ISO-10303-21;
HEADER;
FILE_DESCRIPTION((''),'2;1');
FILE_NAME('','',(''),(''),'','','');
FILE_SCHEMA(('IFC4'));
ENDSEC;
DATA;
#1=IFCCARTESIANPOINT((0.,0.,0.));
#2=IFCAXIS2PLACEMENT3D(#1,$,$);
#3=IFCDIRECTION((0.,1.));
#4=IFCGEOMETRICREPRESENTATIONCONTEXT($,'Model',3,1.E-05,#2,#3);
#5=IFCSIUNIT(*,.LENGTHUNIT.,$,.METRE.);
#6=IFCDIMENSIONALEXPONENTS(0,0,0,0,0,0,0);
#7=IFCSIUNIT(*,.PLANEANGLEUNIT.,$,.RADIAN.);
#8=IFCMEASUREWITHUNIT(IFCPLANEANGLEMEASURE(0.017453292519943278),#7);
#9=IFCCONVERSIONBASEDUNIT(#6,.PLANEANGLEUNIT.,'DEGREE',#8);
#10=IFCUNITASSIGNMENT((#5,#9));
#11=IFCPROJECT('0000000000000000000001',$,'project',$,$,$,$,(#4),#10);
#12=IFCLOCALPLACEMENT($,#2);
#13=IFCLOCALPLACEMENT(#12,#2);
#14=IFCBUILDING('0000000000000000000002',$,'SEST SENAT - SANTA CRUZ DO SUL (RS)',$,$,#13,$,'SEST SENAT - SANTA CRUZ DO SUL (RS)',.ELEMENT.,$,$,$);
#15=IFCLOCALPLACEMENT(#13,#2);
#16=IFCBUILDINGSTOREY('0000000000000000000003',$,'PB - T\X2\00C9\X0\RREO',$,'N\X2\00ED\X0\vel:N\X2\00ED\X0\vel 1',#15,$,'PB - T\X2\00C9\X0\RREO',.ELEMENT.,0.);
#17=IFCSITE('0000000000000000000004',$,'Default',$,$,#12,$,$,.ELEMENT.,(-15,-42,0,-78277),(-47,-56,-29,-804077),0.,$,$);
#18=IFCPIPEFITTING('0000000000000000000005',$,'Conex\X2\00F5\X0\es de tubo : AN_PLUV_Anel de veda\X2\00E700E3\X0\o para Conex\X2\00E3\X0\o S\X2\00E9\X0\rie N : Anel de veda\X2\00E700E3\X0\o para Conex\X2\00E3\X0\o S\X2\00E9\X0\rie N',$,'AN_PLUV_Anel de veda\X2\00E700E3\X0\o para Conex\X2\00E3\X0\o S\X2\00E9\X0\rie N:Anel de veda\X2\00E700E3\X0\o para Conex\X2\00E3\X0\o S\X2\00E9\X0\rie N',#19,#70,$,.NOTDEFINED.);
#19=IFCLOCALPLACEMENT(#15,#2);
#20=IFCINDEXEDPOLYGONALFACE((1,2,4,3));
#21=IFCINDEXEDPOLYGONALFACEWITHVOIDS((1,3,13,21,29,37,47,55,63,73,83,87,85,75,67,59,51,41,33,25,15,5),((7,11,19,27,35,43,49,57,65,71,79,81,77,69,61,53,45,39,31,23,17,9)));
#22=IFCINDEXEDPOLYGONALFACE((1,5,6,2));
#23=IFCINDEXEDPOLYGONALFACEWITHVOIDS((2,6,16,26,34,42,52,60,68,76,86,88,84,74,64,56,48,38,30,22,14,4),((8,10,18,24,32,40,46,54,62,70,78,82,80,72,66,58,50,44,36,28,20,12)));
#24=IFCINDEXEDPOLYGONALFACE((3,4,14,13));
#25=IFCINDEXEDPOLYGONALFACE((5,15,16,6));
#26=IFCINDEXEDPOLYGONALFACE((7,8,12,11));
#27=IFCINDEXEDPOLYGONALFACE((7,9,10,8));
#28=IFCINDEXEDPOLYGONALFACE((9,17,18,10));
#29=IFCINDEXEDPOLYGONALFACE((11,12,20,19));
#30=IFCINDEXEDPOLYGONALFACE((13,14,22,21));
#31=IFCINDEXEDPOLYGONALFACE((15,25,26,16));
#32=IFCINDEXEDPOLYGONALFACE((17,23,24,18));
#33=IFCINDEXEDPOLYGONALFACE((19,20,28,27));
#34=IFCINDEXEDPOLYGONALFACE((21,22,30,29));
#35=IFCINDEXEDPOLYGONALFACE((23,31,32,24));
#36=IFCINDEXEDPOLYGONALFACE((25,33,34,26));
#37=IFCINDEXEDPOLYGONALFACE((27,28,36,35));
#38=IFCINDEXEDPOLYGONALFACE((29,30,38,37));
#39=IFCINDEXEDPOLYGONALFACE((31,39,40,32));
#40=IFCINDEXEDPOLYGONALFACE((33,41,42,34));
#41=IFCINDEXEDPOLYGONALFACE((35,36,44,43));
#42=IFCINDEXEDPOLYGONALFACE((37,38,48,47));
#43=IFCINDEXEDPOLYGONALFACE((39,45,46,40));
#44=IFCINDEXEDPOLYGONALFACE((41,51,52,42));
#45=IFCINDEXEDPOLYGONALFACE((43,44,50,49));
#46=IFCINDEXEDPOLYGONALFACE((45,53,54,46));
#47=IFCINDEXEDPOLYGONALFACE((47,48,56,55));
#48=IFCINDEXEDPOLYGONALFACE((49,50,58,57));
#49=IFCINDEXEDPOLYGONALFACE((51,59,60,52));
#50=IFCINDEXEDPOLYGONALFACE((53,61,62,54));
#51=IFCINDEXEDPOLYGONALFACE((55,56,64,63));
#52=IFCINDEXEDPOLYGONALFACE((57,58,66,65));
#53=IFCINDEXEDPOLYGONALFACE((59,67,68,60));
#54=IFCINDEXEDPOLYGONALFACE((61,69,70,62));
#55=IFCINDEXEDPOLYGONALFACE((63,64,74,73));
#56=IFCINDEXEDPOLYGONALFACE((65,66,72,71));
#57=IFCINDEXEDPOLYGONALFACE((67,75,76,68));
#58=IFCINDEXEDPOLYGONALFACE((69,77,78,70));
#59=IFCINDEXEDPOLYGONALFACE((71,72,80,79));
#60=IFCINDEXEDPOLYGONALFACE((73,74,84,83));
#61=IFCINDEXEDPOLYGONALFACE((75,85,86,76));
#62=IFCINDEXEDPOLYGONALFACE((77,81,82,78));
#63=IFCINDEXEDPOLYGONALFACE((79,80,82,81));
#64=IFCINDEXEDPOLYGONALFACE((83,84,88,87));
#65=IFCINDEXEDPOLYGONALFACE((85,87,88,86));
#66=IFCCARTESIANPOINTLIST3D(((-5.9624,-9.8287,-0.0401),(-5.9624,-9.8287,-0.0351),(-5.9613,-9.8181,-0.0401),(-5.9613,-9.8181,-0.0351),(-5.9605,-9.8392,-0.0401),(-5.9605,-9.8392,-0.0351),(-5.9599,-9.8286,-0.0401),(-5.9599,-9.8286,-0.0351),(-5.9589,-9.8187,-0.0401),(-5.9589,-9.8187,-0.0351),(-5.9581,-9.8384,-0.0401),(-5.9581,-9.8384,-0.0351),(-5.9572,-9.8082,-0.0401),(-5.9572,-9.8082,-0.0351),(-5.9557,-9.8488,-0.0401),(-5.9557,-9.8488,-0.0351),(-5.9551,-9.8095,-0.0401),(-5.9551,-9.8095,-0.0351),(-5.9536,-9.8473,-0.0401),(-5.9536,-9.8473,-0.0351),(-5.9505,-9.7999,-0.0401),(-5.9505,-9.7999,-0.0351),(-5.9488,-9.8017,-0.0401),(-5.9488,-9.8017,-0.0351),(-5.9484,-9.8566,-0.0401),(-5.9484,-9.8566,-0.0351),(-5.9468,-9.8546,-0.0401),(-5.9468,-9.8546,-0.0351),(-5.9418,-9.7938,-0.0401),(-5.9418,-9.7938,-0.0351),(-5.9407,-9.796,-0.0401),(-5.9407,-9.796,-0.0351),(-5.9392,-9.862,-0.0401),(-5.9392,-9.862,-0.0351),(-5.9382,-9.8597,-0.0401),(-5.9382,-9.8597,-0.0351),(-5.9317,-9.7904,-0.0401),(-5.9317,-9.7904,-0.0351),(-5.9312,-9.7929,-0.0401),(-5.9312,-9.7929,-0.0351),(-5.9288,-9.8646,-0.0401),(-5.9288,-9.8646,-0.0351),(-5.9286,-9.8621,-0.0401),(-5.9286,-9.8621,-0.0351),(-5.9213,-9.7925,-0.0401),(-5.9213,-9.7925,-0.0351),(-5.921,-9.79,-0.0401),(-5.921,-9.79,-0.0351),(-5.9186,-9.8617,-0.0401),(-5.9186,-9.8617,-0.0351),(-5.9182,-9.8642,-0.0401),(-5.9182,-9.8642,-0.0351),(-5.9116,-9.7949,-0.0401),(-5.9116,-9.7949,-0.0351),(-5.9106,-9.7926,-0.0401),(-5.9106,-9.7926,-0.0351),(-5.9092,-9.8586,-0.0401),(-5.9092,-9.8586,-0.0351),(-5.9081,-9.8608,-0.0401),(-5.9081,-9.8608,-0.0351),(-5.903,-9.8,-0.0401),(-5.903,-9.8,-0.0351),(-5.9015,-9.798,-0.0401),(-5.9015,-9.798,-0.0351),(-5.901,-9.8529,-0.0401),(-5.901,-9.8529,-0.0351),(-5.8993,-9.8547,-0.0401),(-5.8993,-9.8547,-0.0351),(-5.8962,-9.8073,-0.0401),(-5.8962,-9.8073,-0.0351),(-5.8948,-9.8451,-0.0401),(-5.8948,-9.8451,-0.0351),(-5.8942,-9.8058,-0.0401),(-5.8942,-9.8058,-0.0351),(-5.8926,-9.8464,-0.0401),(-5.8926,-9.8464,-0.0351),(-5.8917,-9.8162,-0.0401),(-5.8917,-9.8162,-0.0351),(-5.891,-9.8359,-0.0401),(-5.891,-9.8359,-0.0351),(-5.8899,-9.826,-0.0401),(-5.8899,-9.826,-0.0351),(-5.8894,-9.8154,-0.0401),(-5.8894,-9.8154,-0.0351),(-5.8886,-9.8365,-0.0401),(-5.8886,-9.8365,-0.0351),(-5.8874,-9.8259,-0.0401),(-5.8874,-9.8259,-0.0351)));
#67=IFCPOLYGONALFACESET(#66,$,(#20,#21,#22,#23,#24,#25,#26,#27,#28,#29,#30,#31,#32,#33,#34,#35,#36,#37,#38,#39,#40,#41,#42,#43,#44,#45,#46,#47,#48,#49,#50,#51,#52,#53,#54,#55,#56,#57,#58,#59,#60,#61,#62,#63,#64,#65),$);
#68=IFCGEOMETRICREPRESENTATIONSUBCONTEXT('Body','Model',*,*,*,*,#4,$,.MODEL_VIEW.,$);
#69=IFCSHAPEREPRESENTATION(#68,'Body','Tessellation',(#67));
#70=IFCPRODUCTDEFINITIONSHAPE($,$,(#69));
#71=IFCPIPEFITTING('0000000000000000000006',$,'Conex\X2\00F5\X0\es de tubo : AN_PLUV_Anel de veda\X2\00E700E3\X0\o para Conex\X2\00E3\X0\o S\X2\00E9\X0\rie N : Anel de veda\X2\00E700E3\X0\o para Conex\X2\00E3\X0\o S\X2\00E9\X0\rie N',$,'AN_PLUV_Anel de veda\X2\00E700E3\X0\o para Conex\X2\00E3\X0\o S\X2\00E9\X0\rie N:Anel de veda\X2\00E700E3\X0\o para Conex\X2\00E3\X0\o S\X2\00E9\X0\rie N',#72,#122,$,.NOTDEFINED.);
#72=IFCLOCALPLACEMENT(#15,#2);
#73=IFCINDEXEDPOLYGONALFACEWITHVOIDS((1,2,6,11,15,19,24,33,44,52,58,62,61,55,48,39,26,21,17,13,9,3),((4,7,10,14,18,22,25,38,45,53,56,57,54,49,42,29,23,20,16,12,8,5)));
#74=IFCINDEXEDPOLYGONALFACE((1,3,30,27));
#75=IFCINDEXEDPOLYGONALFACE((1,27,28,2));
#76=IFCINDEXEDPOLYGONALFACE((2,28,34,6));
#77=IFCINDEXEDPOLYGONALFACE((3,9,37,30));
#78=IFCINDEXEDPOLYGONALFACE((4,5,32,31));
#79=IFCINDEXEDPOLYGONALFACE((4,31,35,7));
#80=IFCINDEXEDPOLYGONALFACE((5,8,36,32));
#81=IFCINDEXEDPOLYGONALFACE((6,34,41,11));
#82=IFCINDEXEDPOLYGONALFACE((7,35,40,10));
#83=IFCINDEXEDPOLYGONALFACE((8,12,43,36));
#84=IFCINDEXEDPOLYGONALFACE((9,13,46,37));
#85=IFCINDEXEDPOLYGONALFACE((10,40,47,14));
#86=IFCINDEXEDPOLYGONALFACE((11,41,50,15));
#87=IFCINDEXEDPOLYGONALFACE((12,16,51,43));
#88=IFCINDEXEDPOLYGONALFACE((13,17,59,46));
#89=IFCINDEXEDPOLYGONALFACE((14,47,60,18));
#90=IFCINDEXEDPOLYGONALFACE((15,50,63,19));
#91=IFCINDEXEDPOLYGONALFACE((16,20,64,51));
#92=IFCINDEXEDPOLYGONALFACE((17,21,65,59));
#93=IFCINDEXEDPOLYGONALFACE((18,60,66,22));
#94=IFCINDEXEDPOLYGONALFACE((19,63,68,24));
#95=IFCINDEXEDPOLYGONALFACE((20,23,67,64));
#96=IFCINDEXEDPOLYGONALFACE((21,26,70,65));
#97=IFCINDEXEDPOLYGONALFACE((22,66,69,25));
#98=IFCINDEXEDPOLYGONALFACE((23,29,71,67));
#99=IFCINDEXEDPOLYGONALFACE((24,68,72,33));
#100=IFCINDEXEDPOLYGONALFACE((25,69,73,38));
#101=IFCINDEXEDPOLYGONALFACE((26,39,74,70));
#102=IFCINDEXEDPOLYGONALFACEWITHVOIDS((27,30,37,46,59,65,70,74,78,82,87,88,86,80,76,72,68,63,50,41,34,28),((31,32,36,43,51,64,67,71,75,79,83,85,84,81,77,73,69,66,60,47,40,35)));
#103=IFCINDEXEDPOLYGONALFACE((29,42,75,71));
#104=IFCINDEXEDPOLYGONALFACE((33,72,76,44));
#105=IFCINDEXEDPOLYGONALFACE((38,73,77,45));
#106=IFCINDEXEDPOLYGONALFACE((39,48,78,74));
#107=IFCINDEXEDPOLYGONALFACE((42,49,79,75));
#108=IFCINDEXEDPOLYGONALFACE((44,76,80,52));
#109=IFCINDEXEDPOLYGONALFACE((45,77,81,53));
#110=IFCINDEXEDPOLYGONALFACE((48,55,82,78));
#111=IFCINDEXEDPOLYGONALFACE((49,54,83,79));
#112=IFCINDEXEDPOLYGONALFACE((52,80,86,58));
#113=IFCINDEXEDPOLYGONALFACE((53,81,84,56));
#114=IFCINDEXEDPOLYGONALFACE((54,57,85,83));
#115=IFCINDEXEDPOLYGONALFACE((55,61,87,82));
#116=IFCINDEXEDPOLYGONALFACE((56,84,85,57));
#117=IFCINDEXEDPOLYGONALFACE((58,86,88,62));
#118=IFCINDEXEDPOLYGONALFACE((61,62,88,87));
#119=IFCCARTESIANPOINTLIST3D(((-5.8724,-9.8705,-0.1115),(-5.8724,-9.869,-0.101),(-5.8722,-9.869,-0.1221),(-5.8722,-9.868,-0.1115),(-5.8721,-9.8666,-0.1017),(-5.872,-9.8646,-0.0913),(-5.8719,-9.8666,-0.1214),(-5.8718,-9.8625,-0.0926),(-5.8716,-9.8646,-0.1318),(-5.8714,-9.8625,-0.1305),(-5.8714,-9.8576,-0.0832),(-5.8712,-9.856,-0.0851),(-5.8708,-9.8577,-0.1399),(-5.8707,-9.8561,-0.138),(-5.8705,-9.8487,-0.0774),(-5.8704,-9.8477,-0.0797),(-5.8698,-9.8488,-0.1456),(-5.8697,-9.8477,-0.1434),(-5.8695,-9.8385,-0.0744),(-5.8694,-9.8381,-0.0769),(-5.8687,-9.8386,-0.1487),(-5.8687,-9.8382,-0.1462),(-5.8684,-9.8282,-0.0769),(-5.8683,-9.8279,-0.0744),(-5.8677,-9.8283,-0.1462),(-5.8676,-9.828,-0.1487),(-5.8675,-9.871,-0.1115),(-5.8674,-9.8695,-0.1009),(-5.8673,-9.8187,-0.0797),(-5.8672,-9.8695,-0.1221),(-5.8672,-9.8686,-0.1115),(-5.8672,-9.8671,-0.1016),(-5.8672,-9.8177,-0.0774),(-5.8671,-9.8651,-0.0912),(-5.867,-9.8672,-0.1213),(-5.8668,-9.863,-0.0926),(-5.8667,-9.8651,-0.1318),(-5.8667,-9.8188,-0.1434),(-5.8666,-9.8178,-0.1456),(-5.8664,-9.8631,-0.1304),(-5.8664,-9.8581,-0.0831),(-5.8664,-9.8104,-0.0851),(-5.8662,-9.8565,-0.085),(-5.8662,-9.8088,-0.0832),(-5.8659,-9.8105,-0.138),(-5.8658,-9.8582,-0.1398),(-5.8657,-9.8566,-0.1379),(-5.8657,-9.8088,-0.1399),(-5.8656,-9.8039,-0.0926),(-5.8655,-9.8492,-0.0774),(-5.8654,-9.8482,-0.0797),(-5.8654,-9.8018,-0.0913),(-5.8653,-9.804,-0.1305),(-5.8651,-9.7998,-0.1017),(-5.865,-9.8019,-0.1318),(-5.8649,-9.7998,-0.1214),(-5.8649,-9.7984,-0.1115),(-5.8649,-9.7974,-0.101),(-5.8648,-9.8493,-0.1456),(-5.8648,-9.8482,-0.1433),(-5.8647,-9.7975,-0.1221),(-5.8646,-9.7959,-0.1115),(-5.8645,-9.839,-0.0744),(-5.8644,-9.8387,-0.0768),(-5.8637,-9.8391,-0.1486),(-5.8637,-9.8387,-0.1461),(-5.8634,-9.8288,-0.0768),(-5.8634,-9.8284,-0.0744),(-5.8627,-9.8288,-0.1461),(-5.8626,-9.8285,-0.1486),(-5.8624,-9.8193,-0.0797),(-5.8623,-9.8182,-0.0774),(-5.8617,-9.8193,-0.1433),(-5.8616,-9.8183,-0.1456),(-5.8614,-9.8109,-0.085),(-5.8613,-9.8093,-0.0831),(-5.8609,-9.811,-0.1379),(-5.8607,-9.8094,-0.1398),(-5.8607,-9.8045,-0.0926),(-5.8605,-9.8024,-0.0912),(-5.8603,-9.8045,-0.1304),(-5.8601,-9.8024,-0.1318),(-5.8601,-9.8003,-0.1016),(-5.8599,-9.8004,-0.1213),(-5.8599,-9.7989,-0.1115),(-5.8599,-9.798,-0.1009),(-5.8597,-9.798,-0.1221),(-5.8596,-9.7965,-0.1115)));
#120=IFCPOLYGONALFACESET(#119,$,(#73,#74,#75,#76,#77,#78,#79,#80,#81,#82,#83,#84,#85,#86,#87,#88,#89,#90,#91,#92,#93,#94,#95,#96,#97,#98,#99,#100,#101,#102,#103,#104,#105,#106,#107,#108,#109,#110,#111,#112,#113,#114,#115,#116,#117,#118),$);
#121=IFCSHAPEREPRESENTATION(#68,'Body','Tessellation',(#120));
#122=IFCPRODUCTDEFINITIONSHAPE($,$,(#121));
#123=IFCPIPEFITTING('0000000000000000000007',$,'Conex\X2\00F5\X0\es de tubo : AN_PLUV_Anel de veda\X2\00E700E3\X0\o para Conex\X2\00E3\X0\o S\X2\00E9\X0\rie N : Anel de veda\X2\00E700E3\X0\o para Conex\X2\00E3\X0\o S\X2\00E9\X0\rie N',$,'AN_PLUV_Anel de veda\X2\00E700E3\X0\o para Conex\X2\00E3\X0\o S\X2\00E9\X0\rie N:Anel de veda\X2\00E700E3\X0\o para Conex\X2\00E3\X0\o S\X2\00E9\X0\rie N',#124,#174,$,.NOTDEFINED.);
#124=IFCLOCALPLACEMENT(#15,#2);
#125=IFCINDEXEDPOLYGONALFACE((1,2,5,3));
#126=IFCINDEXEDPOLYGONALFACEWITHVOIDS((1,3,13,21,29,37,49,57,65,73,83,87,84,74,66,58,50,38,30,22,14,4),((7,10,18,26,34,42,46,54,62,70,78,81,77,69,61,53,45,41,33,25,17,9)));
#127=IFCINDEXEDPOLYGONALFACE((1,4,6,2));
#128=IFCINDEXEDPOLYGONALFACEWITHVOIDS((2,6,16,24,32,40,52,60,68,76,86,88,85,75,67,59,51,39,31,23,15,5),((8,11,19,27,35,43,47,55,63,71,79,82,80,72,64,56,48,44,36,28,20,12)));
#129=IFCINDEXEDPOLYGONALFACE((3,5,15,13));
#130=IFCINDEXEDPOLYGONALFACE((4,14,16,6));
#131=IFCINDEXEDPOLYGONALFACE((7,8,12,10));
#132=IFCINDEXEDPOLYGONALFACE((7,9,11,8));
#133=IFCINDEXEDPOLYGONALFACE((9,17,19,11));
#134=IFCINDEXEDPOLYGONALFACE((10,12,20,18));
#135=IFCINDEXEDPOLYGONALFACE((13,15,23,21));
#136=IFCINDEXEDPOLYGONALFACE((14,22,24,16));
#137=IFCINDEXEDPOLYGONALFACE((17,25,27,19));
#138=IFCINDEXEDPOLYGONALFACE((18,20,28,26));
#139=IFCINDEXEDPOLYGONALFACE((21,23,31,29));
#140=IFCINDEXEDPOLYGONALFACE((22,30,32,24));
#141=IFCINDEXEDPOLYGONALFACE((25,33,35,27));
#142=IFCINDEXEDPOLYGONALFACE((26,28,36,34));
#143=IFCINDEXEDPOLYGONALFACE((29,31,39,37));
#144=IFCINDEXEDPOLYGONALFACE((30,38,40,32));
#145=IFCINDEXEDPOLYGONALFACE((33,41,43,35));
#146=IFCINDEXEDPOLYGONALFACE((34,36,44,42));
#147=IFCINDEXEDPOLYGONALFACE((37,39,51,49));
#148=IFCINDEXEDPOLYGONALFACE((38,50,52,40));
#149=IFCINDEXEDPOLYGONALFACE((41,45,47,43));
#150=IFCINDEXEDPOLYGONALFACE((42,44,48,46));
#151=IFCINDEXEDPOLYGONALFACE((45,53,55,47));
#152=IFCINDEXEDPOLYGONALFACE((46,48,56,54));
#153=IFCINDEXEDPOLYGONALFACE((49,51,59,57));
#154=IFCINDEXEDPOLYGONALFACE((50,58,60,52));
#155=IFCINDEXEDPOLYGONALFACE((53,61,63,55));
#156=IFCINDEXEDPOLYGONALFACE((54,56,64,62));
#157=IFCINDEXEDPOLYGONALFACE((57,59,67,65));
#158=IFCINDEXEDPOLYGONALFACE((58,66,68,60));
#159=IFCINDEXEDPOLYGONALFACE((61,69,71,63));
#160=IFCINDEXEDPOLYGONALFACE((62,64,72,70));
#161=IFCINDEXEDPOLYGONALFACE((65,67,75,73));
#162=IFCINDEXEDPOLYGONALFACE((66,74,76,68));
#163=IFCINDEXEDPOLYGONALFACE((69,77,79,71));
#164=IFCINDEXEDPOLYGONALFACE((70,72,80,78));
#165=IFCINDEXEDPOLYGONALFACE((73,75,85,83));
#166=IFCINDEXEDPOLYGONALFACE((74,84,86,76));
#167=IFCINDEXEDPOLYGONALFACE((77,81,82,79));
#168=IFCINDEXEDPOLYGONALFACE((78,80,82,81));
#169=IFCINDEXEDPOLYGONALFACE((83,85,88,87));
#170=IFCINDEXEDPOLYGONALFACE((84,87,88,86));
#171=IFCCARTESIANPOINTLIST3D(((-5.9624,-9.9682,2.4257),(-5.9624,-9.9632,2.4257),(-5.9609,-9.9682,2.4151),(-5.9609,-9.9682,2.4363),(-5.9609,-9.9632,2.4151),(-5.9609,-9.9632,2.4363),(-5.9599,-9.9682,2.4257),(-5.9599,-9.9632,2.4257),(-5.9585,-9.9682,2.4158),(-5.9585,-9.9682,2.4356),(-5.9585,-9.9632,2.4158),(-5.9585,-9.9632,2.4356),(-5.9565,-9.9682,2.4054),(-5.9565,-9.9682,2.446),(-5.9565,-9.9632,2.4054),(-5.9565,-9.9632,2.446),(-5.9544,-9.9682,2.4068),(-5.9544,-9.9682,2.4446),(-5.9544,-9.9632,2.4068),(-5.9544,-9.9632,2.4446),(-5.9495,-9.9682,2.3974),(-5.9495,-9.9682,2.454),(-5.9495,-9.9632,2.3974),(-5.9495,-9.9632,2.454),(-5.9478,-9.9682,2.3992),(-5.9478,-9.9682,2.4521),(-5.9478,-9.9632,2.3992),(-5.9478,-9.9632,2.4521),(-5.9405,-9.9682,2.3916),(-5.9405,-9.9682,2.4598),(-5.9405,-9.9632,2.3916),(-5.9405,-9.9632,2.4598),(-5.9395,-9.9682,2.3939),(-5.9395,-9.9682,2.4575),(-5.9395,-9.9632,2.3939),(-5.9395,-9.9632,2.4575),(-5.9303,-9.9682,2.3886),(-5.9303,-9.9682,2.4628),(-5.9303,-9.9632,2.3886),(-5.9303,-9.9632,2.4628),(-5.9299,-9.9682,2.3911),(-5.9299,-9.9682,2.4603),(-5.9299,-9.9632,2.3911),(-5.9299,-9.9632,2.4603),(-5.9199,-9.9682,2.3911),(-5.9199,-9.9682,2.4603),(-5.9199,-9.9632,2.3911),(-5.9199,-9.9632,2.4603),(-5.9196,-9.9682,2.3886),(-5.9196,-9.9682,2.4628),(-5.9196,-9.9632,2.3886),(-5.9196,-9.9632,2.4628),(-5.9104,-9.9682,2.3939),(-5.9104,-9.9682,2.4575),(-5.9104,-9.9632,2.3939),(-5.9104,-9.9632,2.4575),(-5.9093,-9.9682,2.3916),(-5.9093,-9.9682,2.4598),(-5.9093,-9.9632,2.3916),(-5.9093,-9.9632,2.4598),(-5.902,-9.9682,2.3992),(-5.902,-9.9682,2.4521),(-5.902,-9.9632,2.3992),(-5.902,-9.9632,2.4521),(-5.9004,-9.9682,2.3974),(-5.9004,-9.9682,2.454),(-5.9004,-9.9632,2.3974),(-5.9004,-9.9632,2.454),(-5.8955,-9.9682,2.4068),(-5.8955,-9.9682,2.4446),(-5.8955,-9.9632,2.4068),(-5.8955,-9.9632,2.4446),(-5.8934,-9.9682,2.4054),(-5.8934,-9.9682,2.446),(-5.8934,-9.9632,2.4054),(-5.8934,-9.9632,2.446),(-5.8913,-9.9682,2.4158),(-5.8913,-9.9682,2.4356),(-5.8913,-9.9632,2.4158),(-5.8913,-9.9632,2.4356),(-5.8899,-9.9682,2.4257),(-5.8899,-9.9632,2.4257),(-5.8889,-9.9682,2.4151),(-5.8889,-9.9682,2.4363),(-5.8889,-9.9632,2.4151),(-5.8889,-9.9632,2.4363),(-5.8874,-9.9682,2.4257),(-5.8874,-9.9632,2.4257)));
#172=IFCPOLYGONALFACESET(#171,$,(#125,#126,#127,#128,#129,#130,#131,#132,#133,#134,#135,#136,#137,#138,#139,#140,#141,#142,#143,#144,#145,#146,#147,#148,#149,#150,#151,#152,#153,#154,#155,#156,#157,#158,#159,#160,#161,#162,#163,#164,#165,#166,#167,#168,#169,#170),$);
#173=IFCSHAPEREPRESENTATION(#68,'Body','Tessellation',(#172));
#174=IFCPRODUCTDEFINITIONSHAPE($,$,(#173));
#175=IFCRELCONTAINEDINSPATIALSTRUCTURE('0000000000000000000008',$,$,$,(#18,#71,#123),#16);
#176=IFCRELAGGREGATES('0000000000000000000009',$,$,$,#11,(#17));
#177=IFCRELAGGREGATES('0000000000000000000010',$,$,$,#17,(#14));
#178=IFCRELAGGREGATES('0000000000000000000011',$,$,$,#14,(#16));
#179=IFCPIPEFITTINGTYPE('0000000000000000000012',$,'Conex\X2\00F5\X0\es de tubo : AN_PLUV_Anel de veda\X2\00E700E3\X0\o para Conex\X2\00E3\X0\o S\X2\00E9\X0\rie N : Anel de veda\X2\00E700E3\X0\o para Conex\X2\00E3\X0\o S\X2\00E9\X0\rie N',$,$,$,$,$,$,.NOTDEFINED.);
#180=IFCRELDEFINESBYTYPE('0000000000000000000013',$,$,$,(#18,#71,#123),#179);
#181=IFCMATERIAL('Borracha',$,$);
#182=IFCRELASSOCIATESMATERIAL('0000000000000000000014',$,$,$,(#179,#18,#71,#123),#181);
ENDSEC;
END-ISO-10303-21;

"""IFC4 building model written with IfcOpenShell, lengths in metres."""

from ifc_helpers import new_model, entity, si_unit, converted_unit, direction, frame, origin, place, context, subcontext, project, spatial, arc, indexed_curve, outline, extrude, source, transform, mapped, material, type_object, type_shapes, element, save


model = new_model("IFC4")

# Units and contexts
model_context = context("Model", 3, precision=1e-05, world=origin(), true_north=direction((0.0, 1.0)))
body_context = subcontext(model_context, "Body", "Model", "MODEL_VIEW")
ifc_project = project(units=[si_unit("LENGTHUNIT", "METRE"), converted_unit("PLANEANGLEUNIT", "DEGREE", entity("IfcPlaneAngleMeasure", 0.017453292519943278), si_unit("PLANEANGLEUNIT", "RADIAN"), dimensions=[0, 0, 0, 0, 0, 0, 0])], contexts=[model_context])

# Site, building, storey
site_placement = place(None, origin())
site = spatial("IfcSite", under=ifc_project, at=site_placement, Name="Default", CompositionType="ELEMENT", RefLatitude=(-15, -42, 0, -78277), RefLongitude=(-47, -56, -29, -804077), RefElevation=0.0)
building_placement = place(site_placement, origin())
building = spatial("IfcBuilding", under=site, at=building_placement, Name="SEST SENAT - SANTA CRUZ DO SUL (RS)", LongName="SEST SENAT - SANTA CRUZ DO SUL (RS)", CompositionType="ELEMENT")
storey_placement = place(building_placement, origin())
storey = spatial("IfcBuildingStorey", under=building, at=storey_placement, Name="PB - TÉRREO", ObjectType="Nível:Nível 1", LongName="PB - TÉRREO", CompositionType="ELEMENT", Elevation=0.0)

# Pipe fittings
ifc_material = material(Name="Borracha")
pipe_fitting_type = type_object("IfcPipeFittingType", Name="Conexões de tubo : AN_PLUV_Anel de vedação para Conexão Série N : Anel de vedação para Conexão Série N", PredefinedType="NOTDEFINED", material=ifc_material)
shared_shape = source(origin(), body_context, "Body", "SweptSolid", [
    extrude(outline(indexed_curve([(-0.0375, 0.0), (0.0, -0.0375), (0.0375, 0.0), (0.0, 0.0375)], segments=[arc(1, 2, 3), arc(3, 4, 1)], self_intersect=False), holes=[indexed_curve([(-0.035, 0.0), (0.0, 0.035), (0.035, 0.0), (0.0, -0.035)], segments=[arc(1, 2, 3), arc(3, 4, 1)], self_intersect=False)]), frame((0.0, 0.0, -0.005)), (0.0, 0.0, 1.0), 0.005),
])
type_shapes(pipe_fitting_type, [shared_shape])
for number, where, z_axis, x_axis, name in (
    (1, (-5.9249, -9.8273, -0.0351), (0.0, 0.0, 1.0), (-0.104523, -0.994522, 0.0), "Conexões de tubo : AN_PLUV_Anel de vedação para Conexão Série N : Anel de vedação para Conexão Série N"),
    (2, (-5.8685, -9.8332, -0.1115), (-0.994473, 0.104518, -0.01), (-0.104523, -0.994522, 0.0), "Conexões de tubo : AN_PLUV_Anel de vedação para Conexão Série N : Anel de vedação para Conexão Série N"),
    (3, (-5.9249, -9.9632, 2.4257), (0.0, 1.0, 0.0), (-1.0, 0.0, 0.0), "Conexões de tubo : AN_PLUV_Anel de vedação para Conexão Série N : Anel de vedação para Conexão Série N"),
):
    element("IfcPipeFitting", number, at=place(storey_placement, frame(where, z_axis=z_axis, x_axis=x_axis)), inside=storey, type_object=pipe_fitting_type, material=ifc_material, Name=name, ObjectType="AN_PLUV_Anel de vedação para Conexão Série N:Anel de vedação para Conexão Série N", PredefinedType="NOTDEFINED", context=body_context, shape_type="MappedRepresentation", body=[
        mapped(shared_shape, transform((0.0, 0.0, 0.0), scale=1.0)),
    ])

save(model, "model.ifc")
